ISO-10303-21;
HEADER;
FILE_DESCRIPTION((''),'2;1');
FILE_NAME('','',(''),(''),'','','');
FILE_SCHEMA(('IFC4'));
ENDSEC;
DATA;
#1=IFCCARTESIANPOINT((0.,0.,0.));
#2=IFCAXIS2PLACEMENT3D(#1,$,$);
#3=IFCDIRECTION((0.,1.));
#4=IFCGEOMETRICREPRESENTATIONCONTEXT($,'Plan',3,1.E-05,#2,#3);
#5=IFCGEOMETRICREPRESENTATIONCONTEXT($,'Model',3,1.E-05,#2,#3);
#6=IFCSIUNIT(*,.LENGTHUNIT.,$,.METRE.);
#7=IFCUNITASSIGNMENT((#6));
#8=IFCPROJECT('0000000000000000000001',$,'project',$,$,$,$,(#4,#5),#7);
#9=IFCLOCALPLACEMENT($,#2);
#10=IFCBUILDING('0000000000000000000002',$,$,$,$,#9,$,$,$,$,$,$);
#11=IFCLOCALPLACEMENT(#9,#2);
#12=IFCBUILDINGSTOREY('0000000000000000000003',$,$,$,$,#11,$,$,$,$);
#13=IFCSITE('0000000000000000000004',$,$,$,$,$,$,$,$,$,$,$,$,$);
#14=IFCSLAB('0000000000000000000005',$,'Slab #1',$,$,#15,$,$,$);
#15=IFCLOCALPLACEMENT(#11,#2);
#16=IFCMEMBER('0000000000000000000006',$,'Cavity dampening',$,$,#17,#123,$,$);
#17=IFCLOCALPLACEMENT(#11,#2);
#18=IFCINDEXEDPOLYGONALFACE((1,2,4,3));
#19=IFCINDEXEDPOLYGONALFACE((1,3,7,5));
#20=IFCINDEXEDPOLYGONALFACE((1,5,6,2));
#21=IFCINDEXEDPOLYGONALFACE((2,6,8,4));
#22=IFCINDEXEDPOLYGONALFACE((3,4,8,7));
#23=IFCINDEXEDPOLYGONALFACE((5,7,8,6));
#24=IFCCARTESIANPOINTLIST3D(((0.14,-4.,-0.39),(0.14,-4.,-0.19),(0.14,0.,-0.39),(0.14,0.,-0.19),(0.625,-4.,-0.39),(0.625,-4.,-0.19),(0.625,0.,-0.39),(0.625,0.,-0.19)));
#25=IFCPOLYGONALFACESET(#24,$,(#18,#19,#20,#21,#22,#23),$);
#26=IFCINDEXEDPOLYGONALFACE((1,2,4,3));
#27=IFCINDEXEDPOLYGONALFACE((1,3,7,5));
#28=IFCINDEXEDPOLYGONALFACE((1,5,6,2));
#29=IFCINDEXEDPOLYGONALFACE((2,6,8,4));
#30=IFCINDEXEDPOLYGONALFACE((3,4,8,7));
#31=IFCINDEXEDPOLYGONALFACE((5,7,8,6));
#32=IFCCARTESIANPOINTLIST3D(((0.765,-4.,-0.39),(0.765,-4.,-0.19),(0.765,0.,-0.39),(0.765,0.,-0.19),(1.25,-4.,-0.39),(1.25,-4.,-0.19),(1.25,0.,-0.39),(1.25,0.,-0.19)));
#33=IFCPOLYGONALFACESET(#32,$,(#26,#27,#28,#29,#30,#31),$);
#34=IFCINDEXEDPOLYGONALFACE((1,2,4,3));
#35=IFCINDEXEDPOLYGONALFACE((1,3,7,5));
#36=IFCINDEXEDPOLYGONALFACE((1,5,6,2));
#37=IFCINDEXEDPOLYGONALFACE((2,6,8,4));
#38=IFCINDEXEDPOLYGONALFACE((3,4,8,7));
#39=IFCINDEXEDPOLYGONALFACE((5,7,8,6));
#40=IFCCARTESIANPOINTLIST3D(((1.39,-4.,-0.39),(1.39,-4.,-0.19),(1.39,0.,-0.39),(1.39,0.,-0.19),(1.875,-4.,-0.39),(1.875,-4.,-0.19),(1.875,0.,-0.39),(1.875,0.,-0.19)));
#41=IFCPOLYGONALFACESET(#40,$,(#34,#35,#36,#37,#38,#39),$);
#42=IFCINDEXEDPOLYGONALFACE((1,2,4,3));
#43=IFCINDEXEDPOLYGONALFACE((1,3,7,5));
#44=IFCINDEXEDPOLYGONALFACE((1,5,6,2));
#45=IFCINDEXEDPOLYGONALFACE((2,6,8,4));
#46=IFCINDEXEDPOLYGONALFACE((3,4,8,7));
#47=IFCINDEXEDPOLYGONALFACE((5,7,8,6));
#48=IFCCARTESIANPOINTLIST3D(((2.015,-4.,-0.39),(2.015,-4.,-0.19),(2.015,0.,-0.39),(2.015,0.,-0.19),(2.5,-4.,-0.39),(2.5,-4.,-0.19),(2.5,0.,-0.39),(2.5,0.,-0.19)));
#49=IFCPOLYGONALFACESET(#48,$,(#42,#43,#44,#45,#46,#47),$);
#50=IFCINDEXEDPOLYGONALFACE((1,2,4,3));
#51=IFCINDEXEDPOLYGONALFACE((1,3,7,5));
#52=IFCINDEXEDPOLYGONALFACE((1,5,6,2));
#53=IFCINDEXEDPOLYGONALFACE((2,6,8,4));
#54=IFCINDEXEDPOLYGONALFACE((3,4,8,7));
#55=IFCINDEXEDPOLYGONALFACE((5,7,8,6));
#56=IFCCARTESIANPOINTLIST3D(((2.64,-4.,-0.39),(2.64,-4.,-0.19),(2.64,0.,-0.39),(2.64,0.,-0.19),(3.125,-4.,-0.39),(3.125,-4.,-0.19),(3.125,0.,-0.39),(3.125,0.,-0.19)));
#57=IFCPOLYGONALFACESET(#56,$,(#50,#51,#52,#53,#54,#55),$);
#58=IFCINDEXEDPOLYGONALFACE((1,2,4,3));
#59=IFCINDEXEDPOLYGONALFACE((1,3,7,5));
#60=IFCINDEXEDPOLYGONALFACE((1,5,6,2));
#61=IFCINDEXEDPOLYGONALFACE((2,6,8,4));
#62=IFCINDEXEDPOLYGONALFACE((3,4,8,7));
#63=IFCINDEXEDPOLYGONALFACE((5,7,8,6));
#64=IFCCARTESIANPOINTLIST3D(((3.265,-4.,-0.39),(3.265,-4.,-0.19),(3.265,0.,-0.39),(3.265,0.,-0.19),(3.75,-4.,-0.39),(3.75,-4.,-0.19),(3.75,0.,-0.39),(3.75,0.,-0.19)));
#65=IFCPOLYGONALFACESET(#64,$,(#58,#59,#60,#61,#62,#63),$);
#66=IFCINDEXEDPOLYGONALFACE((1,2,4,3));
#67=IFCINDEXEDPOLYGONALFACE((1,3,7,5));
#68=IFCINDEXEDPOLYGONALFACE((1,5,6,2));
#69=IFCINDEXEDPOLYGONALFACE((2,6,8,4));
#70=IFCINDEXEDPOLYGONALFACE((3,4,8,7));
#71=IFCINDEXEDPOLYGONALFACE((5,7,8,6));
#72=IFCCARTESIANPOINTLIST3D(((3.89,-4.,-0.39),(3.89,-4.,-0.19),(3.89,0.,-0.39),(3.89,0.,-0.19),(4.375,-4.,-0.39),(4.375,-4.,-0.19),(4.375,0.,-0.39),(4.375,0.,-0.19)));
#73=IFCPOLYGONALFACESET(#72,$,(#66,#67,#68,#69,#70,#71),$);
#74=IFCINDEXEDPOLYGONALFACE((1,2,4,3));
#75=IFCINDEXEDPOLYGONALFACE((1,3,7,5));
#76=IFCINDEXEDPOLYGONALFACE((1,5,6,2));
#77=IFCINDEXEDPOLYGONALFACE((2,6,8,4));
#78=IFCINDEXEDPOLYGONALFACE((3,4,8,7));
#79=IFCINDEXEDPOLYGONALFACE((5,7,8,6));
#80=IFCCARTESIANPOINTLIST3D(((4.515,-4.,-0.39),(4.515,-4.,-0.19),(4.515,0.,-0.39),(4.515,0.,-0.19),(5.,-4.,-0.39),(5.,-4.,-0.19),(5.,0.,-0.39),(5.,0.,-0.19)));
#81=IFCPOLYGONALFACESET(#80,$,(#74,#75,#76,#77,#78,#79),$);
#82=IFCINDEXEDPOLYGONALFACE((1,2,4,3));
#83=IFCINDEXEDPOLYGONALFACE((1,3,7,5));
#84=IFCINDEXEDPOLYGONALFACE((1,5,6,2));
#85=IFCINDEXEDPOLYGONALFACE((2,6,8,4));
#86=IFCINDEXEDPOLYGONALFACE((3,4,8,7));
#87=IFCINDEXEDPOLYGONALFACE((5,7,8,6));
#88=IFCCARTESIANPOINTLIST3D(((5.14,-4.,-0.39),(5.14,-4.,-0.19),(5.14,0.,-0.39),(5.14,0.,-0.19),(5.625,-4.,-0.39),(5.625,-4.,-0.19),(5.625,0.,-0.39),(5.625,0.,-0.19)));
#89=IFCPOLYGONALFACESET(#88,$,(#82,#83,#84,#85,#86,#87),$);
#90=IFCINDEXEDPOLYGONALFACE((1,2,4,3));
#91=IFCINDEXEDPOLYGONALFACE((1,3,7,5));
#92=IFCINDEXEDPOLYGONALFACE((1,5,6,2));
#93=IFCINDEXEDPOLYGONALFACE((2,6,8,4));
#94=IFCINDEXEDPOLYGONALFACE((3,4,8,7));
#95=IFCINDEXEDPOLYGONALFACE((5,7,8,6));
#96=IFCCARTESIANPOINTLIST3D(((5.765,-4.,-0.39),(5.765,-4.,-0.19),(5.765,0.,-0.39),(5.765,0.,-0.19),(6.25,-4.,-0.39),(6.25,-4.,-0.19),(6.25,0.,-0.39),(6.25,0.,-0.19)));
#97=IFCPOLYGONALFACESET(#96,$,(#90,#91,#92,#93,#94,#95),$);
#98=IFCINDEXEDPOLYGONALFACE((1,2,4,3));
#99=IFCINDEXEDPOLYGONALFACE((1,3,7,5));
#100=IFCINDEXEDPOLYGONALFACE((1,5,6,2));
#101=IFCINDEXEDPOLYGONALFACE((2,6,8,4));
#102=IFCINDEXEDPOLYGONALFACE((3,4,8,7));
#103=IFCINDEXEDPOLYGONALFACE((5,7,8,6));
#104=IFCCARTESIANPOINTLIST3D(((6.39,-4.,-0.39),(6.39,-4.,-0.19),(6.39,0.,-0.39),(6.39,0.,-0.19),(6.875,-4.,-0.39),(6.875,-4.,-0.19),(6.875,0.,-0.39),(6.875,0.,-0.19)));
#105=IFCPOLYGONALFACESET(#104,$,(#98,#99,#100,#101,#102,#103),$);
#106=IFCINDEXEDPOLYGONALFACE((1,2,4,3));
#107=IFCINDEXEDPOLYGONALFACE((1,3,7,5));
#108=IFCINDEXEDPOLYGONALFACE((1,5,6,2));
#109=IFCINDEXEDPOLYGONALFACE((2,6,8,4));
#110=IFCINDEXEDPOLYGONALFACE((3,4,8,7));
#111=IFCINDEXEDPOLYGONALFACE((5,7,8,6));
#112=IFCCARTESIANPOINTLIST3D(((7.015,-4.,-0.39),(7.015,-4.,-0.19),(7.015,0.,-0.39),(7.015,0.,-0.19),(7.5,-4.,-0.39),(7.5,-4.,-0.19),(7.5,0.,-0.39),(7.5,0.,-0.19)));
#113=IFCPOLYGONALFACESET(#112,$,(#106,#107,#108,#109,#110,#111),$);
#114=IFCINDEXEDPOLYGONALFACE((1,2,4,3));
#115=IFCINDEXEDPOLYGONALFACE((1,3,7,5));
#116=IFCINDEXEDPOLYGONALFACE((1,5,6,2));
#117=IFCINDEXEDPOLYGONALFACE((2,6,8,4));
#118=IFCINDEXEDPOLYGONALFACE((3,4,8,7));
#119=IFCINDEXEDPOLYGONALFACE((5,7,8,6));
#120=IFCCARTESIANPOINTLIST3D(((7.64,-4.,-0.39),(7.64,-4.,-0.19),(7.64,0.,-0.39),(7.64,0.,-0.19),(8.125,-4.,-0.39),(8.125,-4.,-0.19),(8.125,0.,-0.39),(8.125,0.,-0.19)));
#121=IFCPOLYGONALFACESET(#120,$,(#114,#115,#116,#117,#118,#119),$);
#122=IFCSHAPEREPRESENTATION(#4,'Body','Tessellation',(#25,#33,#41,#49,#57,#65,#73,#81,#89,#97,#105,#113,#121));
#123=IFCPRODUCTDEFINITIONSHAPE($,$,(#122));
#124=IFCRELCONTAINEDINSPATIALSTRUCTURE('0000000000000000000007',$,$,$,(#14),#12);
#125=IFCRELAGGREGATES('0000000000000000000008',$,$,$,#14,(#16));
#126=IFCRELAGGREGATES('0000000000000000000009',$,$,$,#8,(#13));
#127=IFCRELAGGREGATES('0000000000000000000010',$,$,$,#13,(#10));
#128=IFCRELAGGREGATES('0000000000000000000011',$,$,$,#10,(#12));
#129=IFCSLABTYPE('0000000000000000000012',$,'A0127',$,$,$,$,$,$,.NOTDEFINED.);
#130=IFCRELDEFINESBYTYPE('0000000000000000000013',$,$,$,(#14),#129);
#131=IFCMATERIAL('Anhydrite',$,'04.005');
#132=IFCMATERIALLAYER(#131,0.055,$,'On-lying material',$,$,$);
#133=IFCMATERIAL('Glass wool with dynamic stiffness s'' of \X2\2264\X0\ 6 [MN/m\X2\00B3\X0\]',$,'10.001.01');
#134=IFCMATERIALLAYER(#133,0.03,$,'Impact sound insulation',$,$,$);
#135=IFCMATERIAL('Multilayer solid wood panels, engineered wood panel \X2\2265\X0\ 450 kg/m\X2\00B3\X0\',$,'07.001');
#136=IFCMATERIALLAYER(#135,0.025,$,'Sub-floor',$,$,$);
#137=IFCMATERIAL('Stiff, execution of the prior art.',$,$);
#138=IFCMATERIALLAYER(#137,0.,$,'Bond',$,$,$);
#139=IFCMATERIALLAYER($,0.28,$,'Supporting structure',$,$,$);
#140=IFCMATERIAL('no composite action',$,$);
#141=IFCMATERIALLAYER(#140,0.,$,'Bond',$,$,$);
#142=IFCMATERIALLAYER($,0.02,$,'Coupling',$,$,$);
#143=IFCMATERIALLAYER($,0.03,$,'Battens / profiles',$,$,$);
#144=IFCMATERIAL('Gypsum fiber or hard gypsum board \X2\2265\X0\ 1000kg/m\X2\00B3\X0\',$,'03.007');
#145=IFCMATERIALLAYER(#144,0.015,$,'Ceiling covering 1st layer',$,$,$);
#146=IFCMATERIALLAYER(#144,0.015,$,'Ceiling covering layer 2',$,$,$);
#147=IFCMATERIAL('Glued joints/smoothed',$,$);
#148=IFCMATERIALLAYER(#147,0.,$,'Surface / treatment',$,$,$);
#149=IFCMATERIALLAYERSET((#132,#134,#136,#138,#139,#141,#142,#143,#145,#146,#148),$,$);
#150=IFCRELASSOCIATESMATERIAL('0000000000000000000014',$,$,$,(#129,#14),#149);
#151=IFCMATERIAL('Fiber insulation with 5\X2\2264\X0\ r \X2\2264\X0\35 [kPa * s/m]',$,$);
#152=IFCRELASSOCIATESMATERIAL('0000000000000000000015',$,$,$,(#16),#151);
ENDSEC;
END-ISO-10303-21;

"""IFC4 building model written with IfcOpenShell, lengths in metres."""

from ifc_helpers import new_model, si_unit, direction, frame, frame_2d, origin, place, context, project, spatial, rectangle, extrude, material, layer, layer_set, type_object, element, aggregate, save


model = new_model("IFC4")

# Units and contexts
plan_context = context("Plan", 3, precision=1e-05, world=origin(), true_north=direction((0.0, 1.0)))
model_context = context("Model", 3, precision=1e-05, world=origin(), true_north=direction((0.0, 1.0)))
ifc_project = project(units=[si_unit("LENGTHUNIT", "METRE")], contexts=[plan_context, model_context])

# Site, building, storey
site = spatial("IfcSite", under=ifc_project)
building_placement = place(None, origin())
building = spatial("IfcBuilding", under=site, at=building_placement)
storey_placement = place(building_placement, origin())
storey = spatial("IfcBuildingStorey", under=building, at=storey_placement)

# Slab, member
ifc_material_1 = material(Name="Anhydrite", Category="04.005")
ifc_layer_1 = layer(ifc_material_1, 0.055, Name="On-lying material")
ifc_material_2 = material(Name="Glass wool with dynamic stiffness s' of ≤ 6 [MN/m³]", Category="10.001.01")
ifc_layer_2 = layer(ifc_material_2, 0.03, Name="Impact sound insulation")
ifc_material_3 = material(Name="Multilayer solid wood panels, engineered wood panel ≥ 450 kg/m³", Category="07.001")
ifc_layer_3 = layer(ifc_material_3, 0.025, Name="Sub-floor")
ifc_material_4 = material(Name="Stiff, execution of the prior art.")
ifc_layer_4 = layer(ifc_material_4, 0.0, Name="Bond")
ifc_layer_5 = layer(None, 0.28, Name="Supporting structure")
ifc_material_5 = material(Name="no composite action")
ifc_layer_6 = layer(ifc_material_5, 0.0, Name="Bond")
ifc_layer_7 = layer(None, 0.02, Name="Coupling")
ifc_layer_8 = layer(None, 0.03, Name="Battens / profiles")
ifc_material_6 = material(Name="Gypsum fiber or hard gypsum board ≥ 1000kg/m³", Category="03.007")
ifc_layer_9 = layer(ifc_material_6, 0.015, Name="Ceiling covering 1st layer")
ifc_layer_10 = layer(ifc_material_6, 0.015, Name="Ceiling covering layer 2")
ifc_material_7 = material(Name="Glued joints/smoothed")
ifc_layer_11 = layer(ifc_material_7, 0.0, Name="Surface / treatment")
ifc_layer_set = layer_set([ifc_layer_1, ifc_layer_2, ifc_layer_3, ifc_layer_4, ifc_layer_5, ifc_layer_6, ifc_layer_7, ifc_layer_8, ifc_layer_9, ifc_layer_10, ifc_layer_11])
slab_type = type_object("IfcSlabType", Name="A0127", PredefinedType="NOTDEFINED", material=ifc_layer_set)
slab_placement = place(None, frame((0.0, 0.0, 0.0), z_axis=(0.0, 0.0, -1.0), x_axis=(1.0, 0.0, 0.0)))
slab = element("IfcSlab", 1, at=slab_placement, inside=storey, type_object=slab_type, material=ifc_layer_set, Name="Slab #1")
ifc_material_8 = material(Name="Fiber insulation with 5≤ r ≤35 [kPa * s/m]")
member_1_placement = place(slab_placement, origin())
member_1 = element("IfcMember", 2, at=member_1_placement, material=ifc_material_8, Name="Cavity dampening", context=plan_context, shape_type="SweptSolid", body=[
    extrude(rectangle(XDim=0.485, YDim=0.2, at=frame_2d((0.2425, 0.1), x_axis=(1.0, 0.0))), frame((0.14, 4.0, 0.19), z_axis=(0.0, -1.0, 0.0), x_axis=(1.0, 0.0, 0.0)), (0.0, 0.0, 1.0), 4.0),
    extrude(rectangle(XDim=0.485, YDim=0.2, at=frame_2d((0.2425, 0.1), x_axis=(1.0, 0.0))), frame((0.765, 4.0, 0.19), z_axis=(0.0, -1.0, 0.0), x_axis=(1.0, 0.0, 0.0)), (0.0, 0.0, 1.0), 4.0),
    extrude(rectangle(XDim=0.485, YDim=0.2, at=frame_2d((0.2425, 0.1), x_axis=(1.0, 0.0))), frame((1.39, 4.0, 0.19), z_axis=(0.0, -1.0, 0.0), x_axis=(1.0, 0.0, 0.0)), (0.0, 0.0, 1.0), 4.0),
    extrude(rectangle(XDim=0.485, YDim=0.2, at=frame_2d((0.2425, 0.1), x_axis=(1.0, 0.0))), frame((2.015, 4.0, 0.19), z_axis=(0.0, -1.0, 0.0), x_axis=(1.0, 0.0, 0.0)), (0.0, 0.0, 1.0), 4.0),
    extrude(rectangle(XDim=0.485, YDim=0.2, at=frame_2d((0.2425, 0.1), x_axis=(1.0, 0.0))), frame((2.64, 4.0, 0.19), z_axis=(0.0, -1.0, 0.0), x_axis=(1.0, 0.0, 0.0)), (0.0, 0.0, 1.0), 4.0),
    extrude(rectangle(XDim=0.485, YDim=0.2, at=frame_2d((0.2425, 0.1), x_axis=(1.0, 0.0))), frame((3.265, 4.0, 0.19), z_axis=(0.0, -1.0, 0.0), x_axis=(1.0, 0.0, 0.0)), (0.0, 0.0, 1.0), 4.0),
    extrude(rectangle(XDim=0.485, YDim=0.2, at=frame_2d((0.2425, 0.1), x_axis=(1.0, 0.0))), frame((3.89, 4.0, 0.19), z_axis=(0.0, -1.0, 0.0), x_axis=(1.0, 0.0, 0.0)), (0.0, 0.0, 1.0), 4.0),
    extrude(rectangle(XDim=0.485, YDim=0.2, at=frame_2d((0.2425, 0.1), x_axis=(1.0, 0.0))), frame((4.515, 4.0, 0.19), z_axis=(0.0, -1.0, 0.0), x_axis=(1.0, 0.0, 0.0)), (0.0, 0.0, 1.0), 4.0),
    extrude(rectangle(XDim=0.485, YDim=0.2, at=frame_2d((0.2425, 0.1), x_axis=(1.0, 0.0))), frame((5.14, 4.0, 0.19), z_axis=(0.0, -1.0, 0.0), x_axis=(1.0, 0.0, 0.0)), (0.0, 0.0, 1.0), 4.0),
    extrude(rectangle(XDim=0.485, YDim=0.2, at=frame_2d((0.2425, 0.1), x_axis=(1.0, 0.0))), frame((5.765, 4.0, 0.19), z_axis=(0.0, -1.0, 0.0), x_axis=(1.0, 0.0, 0.0)), (0.0, 0.0, 1.0), 4.0),
    extrude(rectangle(XDim=0.485, YDim=0.2, at=frame_2d((0.2425, 0.1), x_axis=(1.0, 0.0))), frame((6.39, 4.0, 0.19), z_axis=(0.0, -1.0, 0.0), x_axis=(1.0, 0.0, 0.0)), (0.0, 0.0, 1.0), 4.0),
    extrude(rectangle(XDim=0.485, YDim=0.2, at=frame_2d((0.2425, 0.1), x_axis=(1.0, 0.0))), frame((7.015, 4.0, 0.19), z_axis=(0.0, -1.0, 0.0), x_axis=(1.0, 0.0, 0.0)), (0.0, 0.0, 1.0), 4.0),
    extrude(rectangle(XDim=0.485, YDim=0.2, at=frame_2d((0.2425, 0.1), x_axis=(1.0, 0.0))), frame((7.64, 4.0, 0.19), z_axis=(0.0, -1.0, 0.0), x_axis=(1.0, 0.0, 0.0)), (0.0, 0.0, 1.0), 4.0),
])
aggregate(slab, [member_1])

save(model, "model.ifc")
